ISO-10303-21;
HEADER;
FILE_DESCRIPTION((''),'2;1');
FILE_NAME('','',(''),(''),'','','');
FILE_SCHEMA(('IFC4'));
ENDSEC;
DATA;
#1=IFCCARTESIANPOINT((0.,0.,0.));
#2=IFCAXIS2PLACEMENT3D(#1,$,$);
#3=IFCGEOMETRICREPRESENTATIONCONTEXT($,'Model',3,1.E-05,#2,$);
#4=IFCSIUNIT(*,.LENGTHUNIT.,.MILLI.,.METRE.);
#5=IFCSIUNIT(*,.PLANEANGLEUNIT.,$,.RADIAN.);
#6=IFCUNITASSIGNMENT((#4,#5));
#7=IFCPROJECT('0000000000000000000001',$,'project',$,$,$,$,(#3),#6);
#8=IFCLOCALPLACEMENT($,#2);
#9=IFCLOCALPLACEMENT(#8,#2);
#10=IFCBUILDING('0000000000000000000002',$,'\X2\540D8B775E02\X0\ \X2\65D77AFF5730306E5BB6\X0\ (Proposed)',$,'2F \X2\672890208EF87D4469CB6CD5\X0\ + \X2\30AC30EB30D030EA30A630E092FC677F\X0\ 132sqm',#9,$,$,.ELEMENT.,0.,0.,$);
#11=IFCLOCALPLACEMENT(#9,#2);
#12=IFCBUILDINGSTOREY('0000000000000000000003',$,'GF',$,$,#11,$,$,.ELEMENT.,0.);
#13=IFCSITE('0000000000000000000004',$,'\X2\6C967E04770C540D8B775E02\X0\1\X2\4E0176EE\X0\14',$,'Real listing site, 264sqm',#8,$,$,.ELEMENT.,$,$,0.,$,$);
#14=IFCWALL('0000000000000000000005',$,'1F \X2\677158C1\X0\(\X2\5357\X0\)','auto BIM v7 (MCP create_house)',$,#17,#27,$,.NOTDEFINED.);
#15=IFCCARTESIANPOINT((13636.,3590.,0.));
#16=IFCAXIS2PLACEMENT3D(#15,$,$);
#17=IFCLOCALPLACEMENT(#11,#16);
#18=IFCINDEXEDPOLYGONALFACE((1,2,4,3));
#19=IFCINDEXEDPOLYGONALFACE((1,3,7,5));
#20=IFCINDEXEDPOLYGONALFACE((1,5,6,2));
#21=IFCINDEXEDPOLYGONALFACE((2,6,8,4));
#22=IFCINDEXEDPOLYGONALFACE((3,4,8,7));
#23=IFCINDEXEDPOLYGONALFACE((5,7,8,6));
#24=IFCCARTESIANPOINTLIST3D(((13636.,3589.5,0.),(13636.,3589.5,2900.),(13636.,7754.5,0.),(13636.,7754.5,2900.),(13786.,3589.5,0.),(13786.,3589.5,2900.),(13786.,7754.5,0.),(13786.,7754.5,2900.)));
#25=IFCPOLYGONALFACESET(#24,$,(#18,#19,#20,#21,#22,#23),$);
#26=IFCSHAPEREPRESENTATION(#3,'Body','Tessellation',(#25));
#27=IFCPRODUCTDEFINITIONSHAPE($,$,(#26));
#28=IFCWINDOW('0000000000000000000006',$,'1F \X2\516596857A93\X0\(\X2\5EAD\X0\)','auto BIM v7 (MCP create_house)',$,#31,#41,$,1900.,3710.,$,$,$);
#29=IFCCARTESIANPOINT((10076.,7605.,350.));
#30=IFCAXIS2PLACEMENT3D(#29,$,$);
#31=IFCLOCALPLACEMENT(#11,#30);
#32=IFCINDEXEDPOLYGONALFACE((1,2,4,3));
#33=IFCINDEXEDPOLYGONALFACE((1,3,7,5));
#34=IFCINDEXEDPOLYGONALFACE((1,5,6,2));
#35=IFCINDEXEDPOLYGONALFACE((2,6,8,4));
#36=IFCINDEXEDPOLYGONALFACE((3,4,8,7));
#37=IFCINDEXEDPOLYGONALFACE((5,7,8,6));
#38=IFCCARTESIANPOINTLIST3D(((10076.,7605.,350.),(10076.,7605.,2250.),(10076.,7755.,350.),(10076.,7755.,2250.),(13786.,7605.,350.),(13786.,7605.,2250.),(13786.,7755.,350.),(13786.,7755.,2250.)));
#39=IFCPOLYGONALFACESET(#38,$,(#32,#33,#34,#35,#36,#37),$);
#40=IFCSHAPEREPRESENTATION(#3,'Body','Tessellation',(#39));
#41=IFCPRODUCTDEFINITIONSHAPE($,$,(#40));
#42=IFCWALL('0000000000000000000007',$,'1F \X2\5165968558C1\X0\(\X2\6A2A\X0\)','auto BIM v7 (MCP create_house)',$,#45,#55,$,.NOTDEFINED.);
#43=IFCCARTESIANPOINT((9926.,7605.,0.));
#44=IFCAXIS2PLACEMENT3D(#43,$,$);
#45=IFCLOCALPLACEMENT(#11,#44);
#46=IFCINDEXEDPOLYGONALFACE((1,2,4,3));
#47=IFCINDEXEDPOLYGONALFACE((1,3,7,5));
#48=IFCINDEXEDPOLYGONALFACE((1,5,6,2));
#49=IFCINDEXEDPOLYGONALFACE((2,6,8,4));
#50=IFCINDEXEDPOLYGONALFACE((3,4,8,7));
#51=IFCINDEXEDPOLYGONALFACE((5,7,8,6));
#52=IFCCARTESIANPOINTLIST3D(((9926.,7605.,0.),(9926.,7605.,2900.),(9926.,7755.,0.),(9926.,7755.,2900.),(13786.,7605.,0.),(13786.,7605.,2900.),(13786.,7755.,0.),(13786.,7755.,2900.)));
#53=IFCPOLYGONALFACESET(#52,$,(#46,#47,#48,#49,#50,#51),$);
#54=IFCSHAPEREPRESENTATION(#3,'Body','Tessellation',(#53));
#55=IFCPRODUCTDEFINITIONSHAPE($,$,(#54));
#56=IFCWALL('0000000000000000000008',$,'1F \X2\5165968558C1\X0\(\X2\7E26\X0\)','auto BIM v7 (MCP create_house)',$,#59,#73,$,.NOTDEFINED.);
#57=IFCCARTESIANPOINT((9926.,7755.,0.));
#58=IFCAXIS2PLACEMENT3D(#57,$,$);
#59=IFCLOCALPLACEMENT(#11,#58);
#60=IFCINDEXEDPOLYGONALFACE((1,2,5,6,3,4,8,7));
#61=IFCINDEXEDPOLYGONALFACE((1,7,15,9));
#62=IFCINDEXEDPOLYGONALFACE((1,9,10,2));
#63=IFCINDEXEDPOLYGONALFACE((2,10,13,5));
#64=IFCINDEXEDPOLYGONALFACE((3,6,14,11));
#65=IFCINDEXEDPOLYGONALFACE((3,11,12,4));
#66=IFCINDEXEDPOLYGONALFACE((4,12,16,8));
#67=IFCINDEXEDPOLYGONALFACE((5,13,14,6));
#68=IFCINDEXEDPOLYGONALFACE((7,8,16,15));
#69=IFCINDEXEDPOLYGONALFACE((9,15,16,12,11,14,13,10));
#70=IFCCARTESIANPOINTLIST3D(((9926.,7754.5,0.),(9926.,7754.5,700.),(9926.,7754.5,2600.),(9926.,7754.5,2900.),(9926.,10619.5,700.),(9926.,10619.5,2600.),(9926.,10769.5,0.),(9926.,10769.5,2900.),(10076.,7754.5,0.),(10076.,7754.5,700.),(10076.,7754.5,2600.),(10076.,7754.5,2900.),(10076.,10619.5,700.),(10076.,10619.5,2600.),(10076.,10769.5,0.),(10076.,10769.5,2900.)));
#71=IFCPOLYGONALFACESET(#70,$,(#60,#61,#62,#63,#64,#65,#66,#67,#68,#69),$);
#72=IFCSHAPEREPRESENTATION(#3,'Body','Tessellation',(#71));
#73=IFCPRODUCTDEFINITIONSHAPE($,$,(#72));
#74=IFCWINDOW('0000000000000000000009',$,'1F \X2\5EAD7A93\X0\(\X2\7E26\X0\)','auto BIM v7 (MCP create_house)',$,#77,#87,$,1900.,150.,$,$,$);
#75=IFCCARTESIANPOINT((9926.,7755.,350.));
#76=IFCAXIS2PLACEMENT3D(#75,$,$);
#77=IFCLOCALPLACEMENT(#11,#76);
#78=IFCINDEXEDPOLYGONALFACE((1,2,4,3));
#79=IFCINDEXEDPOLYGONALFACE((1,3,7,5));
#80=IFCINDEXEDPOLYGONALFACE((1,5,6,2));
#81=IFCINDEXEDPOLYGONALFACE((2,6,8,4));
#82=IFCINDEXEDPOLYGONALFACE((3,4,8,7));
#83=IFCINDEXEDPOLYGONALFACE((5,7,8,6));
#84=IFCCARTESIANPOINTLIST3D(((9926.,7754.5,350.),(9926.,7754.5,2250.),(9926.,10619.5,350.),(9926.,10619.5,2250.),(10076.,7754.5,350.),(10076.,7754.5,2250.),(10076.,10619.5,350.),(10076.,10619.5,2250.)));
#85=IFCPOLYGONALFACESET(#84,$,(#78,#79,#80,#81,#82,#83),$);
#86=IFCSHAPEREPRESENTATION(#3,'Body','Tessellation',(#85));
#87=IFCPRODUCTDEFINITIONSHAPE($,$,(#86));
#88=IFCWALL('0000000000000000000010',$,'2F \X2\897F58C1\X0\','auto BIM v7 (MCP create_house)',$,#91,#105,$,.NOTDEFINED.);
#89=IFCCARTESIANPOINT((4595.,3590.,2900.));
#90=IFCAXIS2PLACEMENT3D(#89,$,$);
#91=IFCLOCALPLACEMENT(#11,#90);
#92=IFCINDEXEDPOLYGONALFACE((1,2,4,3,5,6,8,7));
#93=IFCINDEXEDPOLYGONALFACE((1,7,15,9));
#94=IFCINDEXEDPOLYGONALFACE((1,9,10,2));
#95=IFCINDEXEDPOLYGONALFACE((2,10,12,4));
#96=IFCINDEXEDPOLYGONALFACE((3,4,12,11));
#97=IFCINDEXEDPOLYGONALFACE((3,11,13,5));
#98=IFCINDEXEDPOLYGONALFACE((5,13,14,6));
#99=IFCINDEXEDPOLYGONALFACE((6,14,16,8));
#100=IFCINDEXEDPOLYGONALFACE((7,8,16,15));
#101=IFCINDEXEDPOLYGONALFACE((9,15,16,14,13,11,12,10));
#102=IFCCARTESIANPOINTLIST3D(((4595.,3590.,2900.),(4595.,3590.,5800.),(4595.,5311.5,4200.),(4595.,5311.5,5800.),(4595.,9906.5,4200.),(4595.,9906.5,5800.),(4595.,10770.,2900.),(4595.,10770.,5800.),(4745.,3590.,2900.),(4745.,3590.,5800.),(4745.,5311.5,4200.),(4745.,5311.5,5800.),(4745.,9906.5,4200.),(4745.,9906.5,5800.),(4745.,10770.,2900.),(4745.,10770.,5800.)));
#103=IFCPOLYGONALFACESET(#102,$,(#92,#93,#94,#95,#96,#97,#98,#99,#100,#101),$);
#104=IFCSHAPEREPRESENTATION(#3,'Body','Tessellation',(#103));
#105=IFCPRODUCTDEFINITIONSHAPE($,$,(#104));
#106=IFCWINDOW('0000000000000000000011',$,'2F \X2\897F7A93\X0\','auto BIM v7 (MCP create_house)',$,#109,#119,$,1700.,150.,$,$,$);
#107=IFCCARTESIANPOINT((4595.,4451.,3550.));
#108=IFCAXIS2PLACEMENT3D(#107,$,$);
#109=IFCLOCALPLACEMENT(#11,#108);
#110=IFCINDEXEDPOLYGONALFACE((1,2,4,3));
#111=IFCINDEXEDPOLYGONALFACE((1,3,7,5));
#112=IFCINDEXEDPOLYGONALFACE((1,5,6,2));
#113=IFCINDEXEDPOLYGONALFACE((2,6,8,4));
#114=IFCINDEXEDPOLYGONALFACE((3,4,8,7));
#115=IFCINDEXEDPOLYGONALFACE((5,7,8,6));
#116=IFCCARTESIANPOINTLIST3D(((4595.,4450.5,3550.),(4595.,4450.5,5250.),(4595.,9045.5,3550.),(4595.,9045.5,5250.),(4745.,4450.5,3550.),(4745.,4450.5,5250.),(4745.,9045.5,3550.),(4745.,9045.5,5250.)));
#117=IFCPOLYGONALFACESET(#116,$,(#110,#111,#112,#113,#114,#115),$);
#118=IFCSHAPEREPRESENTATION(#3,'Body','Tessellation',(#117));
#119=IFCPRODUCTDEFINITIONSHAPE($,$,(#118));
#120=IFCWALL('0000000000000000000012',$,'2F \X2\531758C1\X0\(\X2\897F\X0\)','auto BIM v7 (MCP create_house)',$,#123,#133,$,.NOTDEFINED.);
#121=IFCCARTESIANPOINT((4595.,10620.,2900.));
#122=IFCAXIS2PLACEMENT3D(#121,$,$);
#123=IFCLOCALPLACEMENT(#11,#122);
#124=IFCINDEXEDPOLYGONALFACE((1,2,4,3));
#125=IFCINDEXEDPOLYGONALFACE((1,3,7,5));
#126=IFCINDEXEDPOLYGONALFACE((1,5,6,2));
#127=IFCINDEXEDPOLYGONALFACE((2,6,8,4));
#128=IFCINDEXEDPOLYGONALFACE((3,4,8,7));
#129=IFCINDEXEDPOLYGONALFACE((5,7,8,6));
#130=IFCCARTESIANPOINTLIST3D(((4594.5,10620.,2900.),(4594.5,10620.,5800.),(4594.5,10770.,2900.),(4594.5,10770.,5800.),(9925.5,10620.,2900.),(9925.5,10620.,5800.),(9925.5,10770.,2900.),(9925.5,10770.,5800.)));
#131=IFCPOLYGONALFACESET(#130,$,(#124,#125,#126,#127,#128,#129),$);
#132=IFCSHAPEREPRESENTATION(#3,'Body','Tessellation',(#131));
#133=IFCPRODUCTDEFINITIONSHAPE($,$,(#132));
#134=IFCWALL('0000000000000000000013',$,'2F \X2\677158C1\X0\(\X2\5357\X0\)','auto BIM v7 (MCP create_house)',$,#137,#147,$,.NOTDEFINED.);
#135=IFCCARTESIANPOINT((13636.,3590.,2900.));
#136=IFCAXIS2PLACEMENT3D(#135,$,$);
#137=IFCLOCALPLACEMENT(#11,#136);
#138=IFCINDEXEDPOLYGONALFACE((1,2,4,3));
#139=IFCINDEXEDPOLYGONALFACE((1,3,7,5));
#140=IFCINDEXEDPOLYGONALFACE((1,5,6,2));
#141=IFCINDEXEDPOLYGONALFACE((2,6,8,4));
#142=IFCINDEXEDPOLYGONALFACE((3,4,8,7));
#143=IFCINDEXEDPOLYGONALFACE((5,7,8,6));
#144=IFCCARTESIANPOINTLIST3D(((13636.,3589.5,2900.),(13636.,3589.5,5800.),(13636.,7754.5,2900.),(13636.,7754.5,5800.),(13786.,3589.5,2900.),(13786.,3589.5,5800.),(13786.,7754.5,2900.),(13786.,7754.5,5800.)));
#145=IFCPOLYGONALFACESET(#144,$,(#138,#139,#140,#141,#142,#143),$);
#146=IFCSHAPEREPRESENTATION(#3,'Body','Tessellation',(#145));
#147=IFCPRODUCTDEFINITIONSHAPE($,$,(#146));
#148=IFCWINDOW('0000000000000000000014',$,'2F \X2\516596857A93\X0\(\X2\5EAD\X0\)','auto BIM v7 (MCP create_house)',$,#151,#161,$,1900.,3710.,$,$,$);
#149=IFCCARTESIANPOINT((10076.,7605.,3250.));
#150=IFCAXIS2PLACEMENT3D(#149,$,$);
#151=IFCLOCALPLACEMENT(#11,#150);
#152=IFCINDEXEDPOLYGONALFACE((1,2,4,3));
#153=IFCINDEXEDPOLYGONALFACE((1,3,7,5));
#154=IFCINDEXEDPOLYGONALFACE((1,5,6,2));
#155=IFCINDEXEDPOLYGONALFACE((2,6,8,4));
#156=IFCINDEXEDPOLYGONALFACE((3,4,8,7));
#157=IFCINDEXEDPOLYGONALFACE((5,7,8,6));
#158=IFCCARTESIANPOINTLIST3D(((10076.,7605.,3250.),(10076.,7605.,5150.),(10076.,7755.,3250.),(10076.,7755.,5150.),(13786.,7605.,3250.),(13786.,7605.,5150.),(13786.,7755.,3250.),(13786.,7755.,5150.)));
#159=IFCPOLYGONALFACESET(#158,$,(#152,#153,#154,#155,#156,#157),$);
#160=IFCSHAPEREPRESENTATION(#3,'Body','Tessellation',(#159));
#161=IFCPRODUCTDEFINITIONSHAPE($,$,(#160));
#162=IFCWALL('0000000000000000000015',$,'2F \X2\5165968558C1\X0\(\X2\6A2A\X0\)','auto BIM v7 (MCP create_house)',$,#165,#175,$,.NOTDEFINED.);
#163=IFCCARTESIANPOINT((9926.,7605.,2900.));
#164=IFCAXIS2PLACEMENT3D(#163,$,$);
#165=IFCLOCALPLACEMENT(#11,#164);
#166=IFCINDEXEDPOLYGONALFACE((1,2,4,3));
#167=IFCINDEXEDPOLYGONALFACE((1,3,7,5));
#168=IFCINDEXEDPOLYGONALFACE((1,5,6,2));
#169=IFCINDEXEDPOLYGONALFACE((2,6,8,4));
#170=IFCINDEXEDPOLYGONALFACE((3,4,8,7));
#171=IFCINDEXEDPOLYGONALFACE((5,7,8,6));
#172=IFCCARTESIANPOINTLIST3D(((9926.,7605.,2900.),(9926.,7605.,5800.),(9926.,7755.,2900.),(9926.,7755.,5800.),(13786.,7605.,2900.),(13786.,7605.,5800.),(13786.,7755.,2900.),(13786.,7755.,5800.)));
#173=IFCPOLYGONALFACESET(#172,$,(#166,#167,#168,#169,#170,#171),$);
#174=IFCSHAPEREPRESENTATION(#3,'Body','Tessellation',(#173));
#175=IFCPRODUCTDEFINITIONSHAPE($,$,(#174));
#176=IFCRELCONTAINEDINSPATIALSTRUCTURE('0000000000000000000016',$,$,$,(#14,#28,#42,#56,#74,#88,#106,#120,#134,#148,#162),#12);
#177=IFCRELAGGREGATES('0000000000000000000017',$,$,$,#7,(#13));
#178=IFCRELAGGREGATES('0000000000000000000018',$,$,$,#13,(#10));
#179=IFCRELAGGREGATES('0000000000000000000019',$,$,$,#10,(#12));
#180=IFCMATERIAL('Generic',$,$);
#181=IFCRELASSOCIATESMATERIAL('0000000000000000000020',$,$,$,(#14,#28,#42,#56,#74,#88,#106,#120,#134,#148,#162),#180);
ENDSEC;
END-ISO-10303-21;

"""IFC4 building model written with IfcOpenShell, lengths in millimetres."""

from ifc_helpers import new_model, si_unit, frame, frame_2d, origin, place, context, project, spatial, rectangle, extrude, material, element, fill, save


model = new_model("IFC4")

# Units and contexts
model_context = context("Model", 3, precision=1e-05, world=origin())
ifc_project = project(units=[si_unit("LENGTHUNIT", "METRE", prefix="MILLI"), si_unit("PLANEANGLEUNIT", "RADIAN")], contexts=[model_context])

# Site, building, storey
site_placement = place(None, origin())
site = spatial("IfcSite", under=ifc_project, at=site_placement, Name="沖縄県名護市1丁目14", ObjectType="Real listing site, 264sqm", CompositionType="ELEMENT", RefElevation=0.0)
building_placement = place(site_placement, origin())
building = spatial("IfcBuilding", under=site, at=building_placement, Name="名護市 旗竿地の家 (Proposed)", ObjectType="2F 木造軸組構法 + ガルバリウム鋼板 132sqm", CompositionType="ELEMENT", ElevationOfRefHeight=0.0, ElevationOfTerrain=0.0)
storey_placement = place(building_placement, origin())
storey = spatial("IfcBuildingStorey", under=building, at=storey_placement, Name="GF", CompositionType="ELEMENT", Elevation=0.0)

# Shared definitions
ifc_material = material(Name="Generic")

# Wall, opening, window
wall_1_placement = place(storey_placement, frame((13636.0, 3590.0, 0.0)))
wall_1 = element("IfcWall", 1, at=wall_1_placement, inside=storey, material=ifc_material, Name="1F 東壁(南)", Description="auto BIM v7 (MCP create_house)", PredefinedType="NOTDEFINED", context=model_context, shape_type="SweptSolid", body=[
    extrude(rectangle(XDim=150.0, YDim=4165.0, at=frame_2d((75.0, 2082.0))), frame((13636.0, 3590.0, 0.0)), (0.0, 0.0, 1.0), 2900.0),
])
opening_1_placement = place(storey_placement, frame((10076.0, 7605.0, 350.0)))
opening_1 = element("IfcOpeningElement", 2, at=opening_1_placement, cuts=wall_1, PredefinedType="NOTDEFINED", context=model_context, shape_type="SweptSolid", body=[
    extrude(rectangle(XDim=3710.0, YDim=150.0, at=frame_2d((1855.0, 75.0))), frame((10076.0, 7605.0, 350.0)), (0.0, 0.0, 1.0), 1900.0),
])
window_1_placement = place(storey_placement, frame((10076.0, 7605.0, 350.0)))
window_1 = element("IfcWindow", 3, at=window_1_placement, inside=storey, material=ifc_material, Name="1F 入隅窓(庭)", Description="auto BIM v7 (MCP create_house)", OverallHeight=1900.0, OverallWidth=3710.0, context=model_context, shape_type="SweptSolid", body=[
    extrude(rectangle(XDim=3710.0, YDim=150.0, at=frame_2d((1855.0, 75.0))), frame((10076.0, 7605.0, 350.0)), (0.0, 0.0, 1.0), 1900.0),
])
fill(opening_1, window_1)

# Wall
wall_2_placement = place(storey_placement, frame((9926.0, 7605.0, 0.0)))
element("IfcWall", 4, at=wall_2_placement, inside=storey, material=ifc_material, Name="1F 入隅壁(横)", Description="auto BIM v7 (MCP create_house)", PredefinedType="NOTDEFINED", context=model_context, shape_type="SweptSolid", body=[
    extrude(rectangle(XDim=3860.0, YDim=150.0, at=frame_2d((1930.0, 75.0))), frame((9926.0, 7605.0, 0.0)), (0.0, 0.0, 1.0), 2900.0),
])

# Wall, opening, window
wall_3_placement = place(storey_placement, frame((9926.0, 7755.0, 0.0)))
wall_3 = element("IfcWall", 5, at=wall_3_placement, inside=storey, material=ifc_material, Name="1F 入隅壁(縦)", Description="auto BIM v7 (MCP create_house)", PredefinedType="NOTDEFINED", context=model_context, shape_type="SweptSolid", body=[
    extrude(rectangle(XDim=150.0, YDim=3015.0, at=frame_2d((75.0, 1507.0))), frame((9926.0, 7755.0, 0.0)), (0.0, 0.0, 1.0), 2900.0),
])
opening_2_placement = place(storey_placement, frame((9926.0, 7755.0, 350.0)))
opening_2 = element("IfcOpeningElement", 6, at=opening_2_placement, cuts=wall_3, PredefinedType="NOTDEFINED", context=model_context, shape_type="SweptSolid", body=[
    extrude(rectangle(XDim=150.0, YDim=2865.0, at=frame_2d((75.0, 1432.0))), frame((9926.0, 7755.0, 350.0)), (0.0, 0.0, 1.0), 1900.0),
])
window_2_placement = place(storey_placement, frame((9926.0, 7755.0, 350.0)))
window_2 = element("IfcWindow", 7, at=window_2_placement, inside=storey, material=ifc_material, Name="1F 庭窓(縦)", Description="auto BIM v7 (MCP create_house)", OverallHeight=1900.0, OverallWidth=150.0, context=model_context, shape_type="SweptSolid", body=[
    extrude(rectangle(XDim=150.0, YDim=2865.0, at=frame_2d((75.0, 1432.0))), frame((9926.0, 7755.0, 350.0)), (0.0, 0.0, 1.0), 1900.0),
])
fill(opening_2, window_2)

# Wall, opening, window
wall_4_placement = place(storey_placement, frame((4595.0, 3590.0, 2900.0)))
wall_4 = element("IfcWall", 8, at=wall_4_placement, inside=storey, material=ifc_material, Name="2F 西壁", Description="auto BIM v7 (MCP create_house)", PredefinedType="NOTDEFINED", context=model_context, shape_type="SweptSolid", body=[
    extrude(rectangle(XDim=150.0, YDim=7180.0, at=frame_2d((75.0, 3590.0))), frame((4595.0, 3590.0, 2900.0)), (0.0, 0.0, 1.0), 2900.0),
])
opening_3_placement = place(storey_placement, frame((4595.0, 4451.0, 3550.0)))
opening_3 = element("IfcOpeningElement", 9, at=opening_3_placement, cuts=wall_4, PredefinedType="NOTDEFINED", context=model_context, shape_type="SweptSolid", body=[
    extrude(rectangle(XDim=150.0, YDim=4595.0, at=frame_2d((75.0, 2297.0))), frame((4595.0, 4451.0, 3550.0)), (0.0, 0.0, 1.0), 1700.0),
])
window_3_placement = place(storey_placement, frame((4595.0, 4451.0, 3550.0)))
window_3 = element("IfcWindow", 10, at=window_3_placement, inside=storey, material=ifc_material, Name="2F 西窓", Description="auto BIM v7 (MCP create_house)", OverallHeight=1700.0, OverallWidth=150.0, context=model_context, shape_type="SweptSolid", body=[
    extrude(rectangle(XDim=150.0, YDim=4595.0, at=frame_2d((75.0, 2297.0))), frame((4595.0, 4451.0, 3550.0)), (0.0, 0.0, 1.0), 1700.0),
])
fill(opening_3, window_3)

# Wall
wall_5_placement = place(storey_placement, frame((4595.0, 10620.0, 2900.0)))
element("IfcWall", 11, at=wall_5_placement, inside=storey, material=ifc_material, Name="2F 北壁(西)", Description="auto BIM v7 (MCP create_house)", PredefinedType="NOTDEFINED", context=model_context, shape_type="SweptSolid", body=[
    extrude(rectangle(XDim=5331.0, YDim=150.0, at=frame_2d((2665.0, 75.0))), frame((4595.0, 10620.0, 2900.0)), (0.0, 0.0, 1.0), 2900.0),
])

# Wall, opening, window
wall_6_placement = place(storey_placement, frame((13636.0, 3590.0, 2900.0)))
wall_6 = element("IfcWall", 12, at=wall_6_placement, inside=storey, material=ifc_material, Name="2F 東壁(南)", Description="auto BIM v7 (MCP create_house)", PredefinedType="NOTDEFINED", context=model_context, shape_type="SweptSolid", body=[
    extrude(rectangle(XDim=150.0, YDim=4165.0, at=frame_2d((75.0, 2082.0))), frame((13636.0, 3590.0, 2900.0)), (0.0, 0.0, 1.0), 2900.0),
])
opening_4_placement = place(storey_placement, frame((10076.0, 7605.0, 3250.0)))
opening_4 = element("IfcOpeningElement", 13, at=opening_4_placement, cuts=wall_6, PredefinedType="NOTDEFINED", context=model_context, shape_type="SweptSolid", body=[
    extrude(rectangle(XDim=3710.0, YDim=150.0, at=frame_2d((1855.0, 75.0))), frame((10076.0, 7605.0, 3250.0)), (0.0, 0.0, 1.0), 1900.0),
])
window_4_placement = place(storey_placement, frame((10076.0, 7605.0, 3250.0)))
window_4 = element("IfcWindow", 14, at=window_4_placement, inside=storey, material=ifc_material, Name="2F 入隅窓(庭)", Description="auto BIM v7 (MCP create_house)", OverallHeight=1900.0, OverallWidth=3710.0, context=model_context, shape_type="SweptSolid", body=[
    extrude(rectangle(XDim=3710.0, YDim=150.0, at=frame_2d((1855.0, 75.0))), frame((10076.0, 7605.0, 3250.0)), (0.0, 0.0, 1.0), 1900.0),
])
fill(opening_4, window_4)

# Wall
wall_7_placement = place(storey_placement, frame((9926.0, 7605.0, 2900.0)))
element("IfcWall", 15, at=wall_7_placement, inside=storey, material=ifc_material, Name="2F 入隅壁(横)", Description="auto BIM v7 (MCP create_house)", PredefinedType="NOTDEFINED", context=model_context, shape_type="SweptSolid", body=[
    extrude(rectangle(XDim=3860.0, YDim=150.0, at=frame_2d((1930.0, 75.0))), frame((9926.0, 7605.0, 2900.0)), (0.0, 0.0, 1.0), 2900.0),
])

save(model, "model.ifc")
